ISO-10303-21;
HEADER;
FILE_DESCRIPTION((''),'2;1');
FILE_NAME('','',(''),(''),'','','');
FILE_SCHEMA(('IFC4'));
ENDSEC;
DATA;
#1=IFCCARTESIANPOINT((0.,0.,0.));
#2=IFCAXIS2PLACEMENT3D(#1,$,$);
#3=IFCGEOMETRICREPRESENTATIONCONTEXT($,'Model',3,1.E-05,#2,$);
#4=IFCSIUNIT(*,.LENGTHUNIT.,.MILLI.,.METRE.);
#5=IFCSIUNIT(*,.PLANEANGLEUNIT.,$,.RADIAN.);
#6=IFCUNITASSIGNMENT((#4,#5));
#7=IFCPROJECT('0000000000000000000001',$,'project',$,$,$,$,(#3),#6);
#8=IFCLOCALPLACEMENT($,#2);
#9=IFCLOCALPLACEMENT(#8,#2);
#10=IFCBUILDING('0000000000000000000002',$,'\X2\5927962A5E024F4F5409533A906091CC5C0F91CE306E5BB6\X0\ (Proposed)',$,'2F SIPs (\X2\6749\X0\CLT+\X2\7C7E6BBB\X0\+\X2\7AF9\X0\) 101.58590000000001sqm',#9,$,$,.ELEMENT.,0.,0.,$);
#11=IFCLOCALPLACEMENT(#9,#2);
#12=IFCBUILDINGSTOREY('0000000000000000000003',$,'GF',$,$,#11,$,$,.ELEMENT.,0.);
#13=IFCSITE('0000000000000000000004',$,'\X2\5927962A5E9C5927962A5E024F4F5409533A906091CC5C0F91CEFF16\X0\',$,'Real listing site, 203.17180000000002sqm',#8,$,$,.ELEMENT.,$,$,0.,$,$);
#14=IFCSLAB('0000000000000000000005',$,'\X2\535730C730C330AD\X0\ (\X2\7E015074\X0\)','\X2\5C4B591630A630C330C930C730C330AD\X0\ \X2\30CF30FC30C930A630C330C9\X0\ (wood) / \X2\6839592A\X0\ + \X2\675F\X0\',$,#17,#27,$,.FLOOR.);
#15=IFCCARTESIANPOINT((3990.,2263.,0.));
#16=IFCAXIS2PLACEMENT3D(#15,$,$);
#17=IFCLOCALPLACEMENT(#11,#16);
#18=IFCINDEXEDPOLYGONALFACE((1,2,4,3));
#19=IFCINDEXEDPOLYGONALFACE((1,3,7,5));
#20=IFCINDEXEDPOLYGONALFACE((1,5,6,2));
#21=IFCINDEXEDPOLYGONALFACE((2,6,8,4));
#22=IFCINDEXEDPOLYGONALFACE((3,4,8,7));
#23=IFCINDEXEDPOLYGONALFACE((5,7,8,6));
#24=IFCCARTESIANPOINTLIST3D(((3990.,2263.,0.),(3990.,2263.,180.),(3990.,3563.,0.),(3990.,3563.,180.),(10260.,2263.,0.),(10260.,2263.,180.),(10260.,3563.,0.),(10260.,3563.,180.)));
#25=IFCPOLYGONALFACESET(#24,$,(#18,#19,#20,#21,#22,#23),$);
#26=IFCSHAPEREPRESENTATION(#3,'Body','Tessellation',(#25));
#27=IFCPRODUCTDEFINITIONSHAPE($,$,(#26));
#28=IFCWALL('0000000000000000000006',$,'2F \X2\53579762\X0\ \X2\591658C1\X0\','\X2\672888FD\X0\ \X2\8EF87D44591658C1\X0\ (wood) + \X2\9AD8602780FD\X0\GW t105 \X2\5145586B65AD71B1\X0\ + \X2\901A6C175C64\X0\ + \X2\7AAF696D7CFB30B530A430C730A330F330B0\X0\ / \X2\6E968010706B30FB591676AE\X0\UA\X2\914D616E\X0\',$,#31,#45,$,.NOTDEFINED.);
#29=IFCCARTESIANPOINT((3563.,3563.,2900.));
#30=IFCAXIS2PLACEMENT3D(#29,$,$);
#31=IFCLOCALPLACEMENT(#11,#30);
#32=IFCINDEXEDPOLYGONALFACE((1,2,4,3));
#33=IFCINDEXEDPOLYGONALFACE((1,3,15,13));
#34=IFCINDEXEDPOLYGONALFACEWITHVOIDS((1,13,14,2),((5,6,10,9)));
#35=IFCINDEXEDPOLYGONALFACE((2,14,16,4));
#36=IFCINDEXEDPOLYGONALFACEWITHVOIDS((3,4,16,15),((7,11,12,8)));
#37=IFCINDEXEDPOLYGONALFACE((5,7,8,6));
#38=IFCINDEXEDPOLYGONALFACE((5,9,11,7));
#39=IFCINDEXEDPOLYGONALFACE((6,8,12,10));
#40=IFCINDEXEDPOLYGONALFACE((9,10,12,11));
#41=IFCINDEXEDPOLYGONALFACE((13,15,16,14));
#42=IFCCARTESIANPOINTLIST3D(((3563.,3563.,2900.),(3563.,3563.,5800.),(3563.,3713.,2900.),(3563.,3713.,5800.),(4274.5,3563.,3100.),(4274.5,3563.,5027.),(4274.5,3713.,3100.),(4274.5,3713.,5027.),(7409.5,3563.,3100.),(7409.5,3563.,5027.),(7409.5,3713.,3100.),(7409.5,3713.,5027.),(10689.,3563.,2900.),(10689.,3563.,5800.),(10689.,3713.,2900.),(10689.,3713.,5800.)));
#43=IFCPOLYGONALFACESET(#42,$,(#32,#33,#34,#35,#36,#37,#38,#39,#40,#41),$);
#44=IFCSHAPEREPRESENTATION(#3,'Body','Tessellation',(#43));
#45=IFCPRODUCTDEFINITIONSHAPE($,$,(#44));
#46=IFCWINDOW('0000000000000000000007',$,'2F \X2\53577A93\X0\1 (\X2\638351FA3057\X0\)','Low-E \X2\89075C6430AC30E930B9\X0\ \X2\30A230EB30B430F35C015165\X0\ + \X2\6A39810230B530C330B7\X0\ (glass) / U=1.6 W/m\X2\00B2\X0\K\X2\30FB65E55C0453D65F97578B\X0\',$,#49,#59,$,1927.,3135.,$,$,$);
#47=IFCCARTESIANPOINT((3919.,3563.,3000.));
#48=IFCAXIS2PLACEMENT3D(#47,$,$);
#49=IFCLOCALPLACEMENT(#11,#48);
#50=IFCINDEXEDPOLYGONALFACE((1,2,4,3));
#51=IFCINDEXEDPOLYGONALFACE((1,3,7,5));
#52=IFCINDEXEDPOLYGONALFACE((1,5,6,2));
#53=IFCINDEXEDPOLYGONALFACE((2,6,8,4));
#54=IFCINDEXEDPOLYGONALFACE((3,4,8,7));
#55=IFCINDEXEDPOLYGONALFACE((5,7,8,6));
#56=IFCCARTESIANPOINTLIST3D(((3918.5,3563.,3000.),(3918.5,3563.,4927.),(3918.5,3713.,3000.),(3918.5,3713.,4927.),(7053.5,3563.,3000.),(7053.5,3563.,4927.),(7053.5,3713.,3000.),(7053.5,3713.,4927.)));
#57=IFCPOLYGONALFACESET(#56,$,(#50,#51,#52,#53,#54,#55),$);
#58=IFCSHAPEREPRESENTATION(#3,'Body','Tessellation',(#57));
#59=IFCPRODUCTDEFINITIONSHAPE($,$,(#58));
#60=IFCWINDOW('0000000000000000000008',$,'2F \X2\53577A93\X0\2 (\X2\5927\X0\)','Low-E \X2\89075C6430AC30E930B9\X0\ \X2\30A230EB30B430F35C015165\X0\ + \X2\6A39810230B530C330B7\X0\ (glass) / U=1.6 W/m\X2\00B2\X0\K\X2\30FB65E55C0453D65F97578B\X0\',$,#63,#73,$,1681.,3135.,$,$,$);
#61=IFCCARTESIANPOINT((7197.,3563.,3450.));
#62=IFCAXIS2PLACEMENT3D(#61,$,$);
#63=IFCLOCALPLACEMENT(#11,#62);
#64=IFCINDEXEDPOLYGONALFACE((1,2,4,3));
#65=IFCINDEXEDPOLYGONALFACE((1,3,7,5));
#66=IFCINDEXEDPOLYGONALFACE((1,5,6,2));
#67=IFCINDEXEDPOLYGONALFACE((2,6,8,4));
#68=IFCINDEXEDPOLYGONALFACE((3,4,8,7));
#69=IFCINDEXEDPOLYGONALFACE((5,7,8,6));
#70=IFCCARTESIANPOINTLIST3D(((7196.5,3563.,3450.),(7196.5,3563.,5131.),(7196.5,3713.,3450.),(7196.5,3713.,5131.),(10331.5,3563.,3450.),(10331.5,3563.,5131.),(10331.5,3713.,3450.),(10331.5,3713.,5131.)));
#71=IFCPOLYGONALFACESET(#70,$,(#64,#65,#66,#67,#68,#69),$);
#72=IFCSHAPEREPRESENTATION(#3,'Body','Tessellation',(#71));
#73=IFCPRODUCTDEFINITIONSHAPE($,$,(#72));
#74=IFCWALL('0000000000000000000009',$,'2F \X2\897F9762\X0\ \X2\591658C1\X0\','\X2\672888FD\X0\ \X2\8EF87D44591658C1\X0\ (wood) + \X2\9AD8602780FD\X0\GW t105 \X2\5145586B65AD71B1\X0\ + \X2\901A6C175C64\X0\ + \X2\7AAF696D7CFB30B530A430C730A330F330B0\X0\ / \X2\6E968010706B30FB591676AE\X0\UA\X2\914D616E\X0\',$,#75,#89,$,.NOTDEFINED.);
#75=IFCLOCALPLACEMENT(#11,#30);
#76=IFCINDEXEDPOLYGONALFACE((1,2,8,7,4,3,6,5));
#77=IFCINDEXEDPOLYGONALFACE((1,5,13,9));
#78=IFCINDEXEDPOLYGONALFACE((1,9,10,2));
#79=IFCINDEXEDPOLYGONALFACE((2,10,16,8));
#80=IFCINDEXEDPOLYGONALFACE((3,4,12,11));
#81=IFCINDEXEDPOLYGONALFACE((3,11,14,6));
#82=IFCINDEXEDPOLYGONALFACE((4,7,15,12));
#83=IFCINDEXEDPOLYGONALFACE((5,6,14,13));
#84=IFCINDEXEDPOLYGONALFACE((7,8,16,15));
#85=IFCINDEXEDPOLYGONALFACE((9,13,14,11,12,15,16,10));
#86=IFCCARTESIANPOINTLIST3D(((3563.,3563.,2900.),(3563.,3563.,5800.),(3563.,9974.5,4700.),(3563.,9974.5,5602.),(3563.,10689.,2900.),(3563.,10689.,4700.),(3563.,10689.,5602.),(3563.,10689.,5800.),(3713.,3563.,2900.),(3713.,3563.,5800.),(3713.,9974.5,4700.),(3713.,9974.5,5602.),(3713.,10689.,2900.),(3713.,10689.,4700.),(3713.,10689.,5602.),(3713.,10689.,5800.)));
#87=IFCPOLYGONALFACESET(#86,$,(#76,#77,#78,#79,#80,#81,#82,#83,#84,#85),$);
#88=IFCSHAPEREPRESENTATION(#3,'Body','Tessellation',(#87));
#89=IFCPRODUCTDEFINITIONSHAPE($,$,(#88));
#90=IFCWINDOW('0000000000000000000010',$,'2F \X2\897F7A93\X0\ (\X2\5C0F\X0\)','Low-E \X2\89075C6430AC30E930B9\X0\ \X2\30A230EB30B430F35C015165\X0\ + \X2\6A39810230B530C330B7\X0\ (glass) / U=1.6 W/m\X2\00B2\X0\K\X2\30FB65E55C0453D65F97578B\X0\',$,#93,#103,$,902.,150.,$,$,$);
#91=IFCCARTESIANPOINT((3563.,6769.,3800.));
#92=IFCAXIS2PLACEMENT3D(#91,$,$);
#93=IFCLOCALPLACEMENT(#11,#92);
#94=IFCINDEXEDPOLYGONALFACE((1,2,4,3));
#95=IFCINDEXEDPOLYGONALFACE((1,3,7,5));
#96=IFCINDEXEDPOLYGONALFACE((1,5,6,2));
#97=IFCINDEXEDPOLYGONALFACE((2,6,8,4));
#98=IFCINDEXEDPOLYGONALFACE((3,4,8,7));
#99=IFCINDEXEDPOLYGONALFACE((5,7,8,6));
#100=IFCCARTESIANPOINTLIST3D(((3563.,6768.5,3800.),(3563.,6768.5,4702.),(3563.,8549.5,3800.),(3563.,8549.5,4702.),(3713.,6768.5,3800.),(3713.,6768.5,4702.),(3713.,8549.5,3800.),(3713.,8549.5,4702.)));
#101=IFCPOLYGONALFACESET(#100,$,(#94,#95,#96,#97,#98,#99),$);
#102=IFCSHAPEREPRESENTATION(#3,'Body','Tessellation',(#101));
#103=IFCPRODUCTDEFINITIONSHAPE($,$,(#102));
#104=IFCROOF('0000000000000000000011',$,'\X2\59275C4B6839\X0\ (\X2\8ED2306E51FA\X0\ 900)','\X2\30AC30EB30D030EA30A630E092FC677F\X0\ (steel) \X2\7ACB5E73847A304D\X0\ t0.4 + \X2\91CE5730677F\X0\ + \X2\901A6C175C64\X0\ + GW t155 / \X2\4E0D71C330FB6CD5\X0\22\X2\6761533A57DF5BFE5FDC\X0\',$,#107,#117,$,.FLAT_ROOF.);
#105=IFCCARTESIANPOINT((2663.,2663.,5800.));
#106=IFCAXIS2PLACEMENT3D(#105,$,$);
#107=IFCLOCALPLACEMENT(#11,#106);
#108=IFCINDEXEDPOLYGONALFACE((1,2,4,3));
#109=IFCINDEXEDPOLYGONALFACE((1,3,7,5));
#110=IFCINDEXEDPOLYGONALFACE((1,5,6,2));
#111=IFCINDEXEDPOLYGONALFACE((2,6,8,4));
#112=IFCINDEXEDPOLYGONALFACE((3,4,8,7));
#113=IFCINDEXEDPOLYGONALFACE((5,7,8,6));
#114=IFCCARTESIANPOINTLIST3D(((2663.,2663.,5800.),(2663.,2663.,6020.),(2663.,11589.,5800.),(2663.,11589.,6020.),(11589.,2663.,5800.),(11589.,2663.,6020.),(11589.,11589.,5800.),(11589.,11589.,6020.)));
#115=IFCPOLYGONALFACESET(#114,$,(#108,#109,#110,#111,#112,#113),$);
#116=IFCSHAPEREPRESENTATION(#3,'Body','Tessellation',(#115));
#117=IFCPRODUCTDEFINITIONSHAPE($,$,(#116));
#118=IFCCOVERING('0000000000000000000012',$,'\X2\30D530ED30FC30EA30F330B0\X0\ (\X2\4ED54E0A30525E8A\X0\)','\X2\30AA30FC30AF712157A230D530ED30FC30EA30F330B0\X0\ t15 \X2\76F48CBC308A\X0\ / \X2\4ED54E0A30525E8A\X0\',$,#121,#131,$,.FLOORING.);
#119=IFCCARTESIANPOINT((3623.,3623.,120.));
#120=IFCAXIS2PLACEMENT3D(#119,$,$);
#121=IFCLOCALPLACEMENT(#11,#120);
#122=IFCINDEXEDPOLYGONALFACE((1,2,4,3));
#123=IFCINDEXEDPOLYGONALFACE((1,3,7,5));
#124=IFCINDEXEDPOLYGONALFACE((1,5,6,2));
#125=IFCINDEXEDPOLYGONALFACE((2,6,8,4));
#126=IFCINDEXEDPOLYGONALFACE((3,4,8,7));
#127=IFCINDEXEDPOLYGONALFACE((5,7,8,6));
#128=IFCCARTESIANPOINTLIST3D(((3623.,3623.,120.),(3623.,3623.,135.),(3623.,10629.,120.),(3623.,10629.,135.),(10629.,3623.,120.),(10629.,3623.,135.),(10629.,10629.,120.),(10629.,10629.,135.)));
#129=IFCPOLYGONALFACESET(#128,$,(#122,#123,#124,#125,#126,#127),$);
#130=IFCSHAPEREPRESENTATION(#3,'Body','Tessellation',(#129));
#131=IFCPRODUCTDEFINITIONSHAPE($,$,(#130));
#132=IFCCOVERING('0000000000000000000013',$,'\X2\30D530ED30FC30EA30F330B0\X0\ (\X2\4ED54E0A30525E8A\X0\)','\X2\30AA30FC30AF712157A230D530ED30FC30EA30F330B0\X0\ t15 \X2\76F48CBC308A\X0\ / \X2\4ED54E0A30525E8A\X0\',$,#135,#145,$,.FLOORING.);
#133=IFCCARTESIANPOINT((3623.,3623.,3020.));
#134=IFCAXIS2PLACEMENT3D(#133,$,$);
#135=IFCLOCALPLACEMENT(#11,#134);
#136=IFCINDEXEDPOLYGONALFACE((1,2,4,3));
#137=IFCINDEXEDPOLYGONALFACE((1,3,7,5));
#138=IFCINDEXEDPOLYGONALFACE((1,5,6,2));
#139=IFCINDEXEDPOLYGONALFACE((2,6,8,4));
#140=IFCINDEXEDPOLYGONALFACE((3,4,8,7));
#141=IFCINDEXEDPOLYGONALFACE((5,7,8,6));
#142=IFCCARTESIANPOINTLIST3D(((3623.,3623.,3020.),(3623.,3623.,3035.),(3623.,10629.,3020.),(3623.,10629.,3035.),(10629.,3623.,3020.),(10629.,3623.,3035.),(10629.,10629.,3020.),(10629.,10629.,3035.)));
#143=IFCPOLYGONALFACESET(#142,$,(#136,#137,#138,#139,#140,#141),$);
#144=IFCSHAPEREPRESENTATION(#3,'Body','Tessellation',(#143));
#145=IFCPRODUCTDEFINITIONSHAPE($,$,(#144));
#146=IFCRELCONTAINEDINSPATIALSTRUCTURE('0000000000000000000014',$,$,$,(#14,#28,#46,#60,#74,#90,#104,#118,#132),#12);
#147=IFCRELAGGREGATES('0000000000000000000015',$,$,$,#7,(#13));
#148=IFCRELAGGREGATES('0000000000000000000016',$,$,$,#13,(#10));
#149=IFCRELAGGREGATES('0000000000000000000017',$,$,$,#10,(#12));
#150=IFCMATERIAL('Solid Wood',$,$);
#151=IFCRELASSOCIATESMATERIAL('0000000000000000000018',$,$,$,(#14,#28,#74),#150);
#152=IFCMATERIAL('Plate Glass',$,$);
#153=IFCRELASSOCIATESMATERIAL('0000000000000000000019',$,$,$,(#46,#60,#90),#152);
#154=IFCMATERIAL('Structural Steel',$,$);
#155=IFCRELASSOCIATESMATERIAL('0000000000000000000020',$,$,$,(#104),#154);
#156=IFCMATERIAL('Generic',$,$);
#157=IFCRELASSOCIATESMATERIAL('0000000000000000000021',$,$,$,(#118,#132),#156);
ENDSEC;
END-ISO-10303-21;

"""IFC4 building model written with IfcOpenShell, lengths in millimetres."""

from ifc_helpers import new_model, si_unit, frame, frame_2d, origin, place, context, project, spatial, rectangle, extrude, material, element, fill, save


model = new_model("IFC4")

# Units and contexts
model_context = context("Model", 3, precision=1e-05, world=origin())
ifc_project = project(units=[si_unit("LENGTHUNIT", "METRE", prefix="MILLI"), si_unit("PLANEANGLEUNIT", "RADIAN")], contexts=[model_context])

# Site, building, storey
site_placement = place(None, origin())
site = spatial("IfcSite", under=ifc_project, at=site_placement, Name="大阪府大阪市住吉区遠里小野６", ObjectType="Real listing site, 203.17180000000002sqm", CompositionType="ELEMENT", RefElevation=0.0)
building_placement = place(site_placement, origin())
building = spatial("IfcBuilding", under=site, at=building_placement, Name="大阪市住吉区遠里小野の家 (Proposed)", ObjectType="2F SIPs (杉CLT+籾殻+竹) 101.58590000000001sqm", CompositionType="ELEMENT", ElevationOfRefHeight=0.0, ElevationOfTerrain=0.0)
storey_placement = place(building_placement, origin())
storey = spatial("IfcBuildingStorey", under=building, at=storey_placement, Name="GF", CompositionType="ELEMENT", Elevation=0.0)

# Slab
ifc_material_1 = material(Name="Solid Wood")
slab_1_placement = place(storey_placement, frame((3990.0, 2263.0, 0.0)))
element("IfcSlab", 1, at=slab_1_placement, inside=storey, material=ifc_material_1, Name="南デッキ (縁側)", Description="屋外ウッドデッキ ハードウッド (wood) / 根太 + 束", PredefinedType="FLOOR", context=model_context, shape_type="SweptSolid", body=[
    extrude(rectangle(XDim=6270.0, YDim=1300.0, at=frame_2d((3135.0, 650.0))), frame((3990.0, 2263.0, 0.0)), (0.0, 0.0, 1.0), 180.0),
])

# Shared definitions
ifc_material_2 = material(Name="Plate Glass")

# Wall, openings, windows
wall_1_placement = place(storey_placement, frame((3563.0, 3563.0, 2900.0)))
wall_1 = element("IfcWall", 2, at=wall_1_placement, inside=storey, material=ifc_material_1, Name="2F 南面 外壁", Description="木製 軸組外壁 (wood) + 高性能GW t105 充填断熱 + 通気層 + 窯業系サイディング / 準耐火・外皮UA配慮", PredefinedType="NOTDEFINED", context=model_context, shape_type="SweptSolid", body=[
    extrude(rectangle(XDim=7126.0, YDim=150.0, at=frame_2d((3563.0, 75.0))), frame((3563.0, 3563.0, 2900.0)), (0.0, 0.0, 1.0), 2900.0),
])
opening_1_placement = place(storey_placement, frame((3919.0, 3563.0, 3000.0)))
opening_1 = element("IfcOpeningElement", 3, at=opening_1_placement, cuts=wall_1, PredefinedType="NOTDEFINED", context=model_context, shape_type="SweptSolid", body=[
    extrude(rectangle(XDim=3135.0, YDim=150.0, at=frame_2d((1567.0, 75.0))), frame((3919.0, 3563.0, 3000.0)), (0.0, 0.0, 1.0), 1927.0),
])
opening_2_placement = place(storey_placement, frame((7197.0, 3563.0, 3450.0)))
opening_2 = element("IfcOpeningElement", 4, at=opening_2_placement, cuts=wall_1, PredefinedType="NOTDEFINED", context=model_context, shape_type="SweptSolid", body=[
    extrude(rectangle(XDim=3135.0, YDim=150.0, at=frame_2d((1567.0, 75.0))), frame((7197.0, 3563.0, 3450.0)), (0.0, 0.0, 1.0), 1681.0),
])
window_1_placement = place(storey_placement, frame((3919.0, 3563.0, 3000.0)))
window_1 = element("IfcWindow", 5, at=window_1_placement, inside=storey, material=ifc_material_2, Name="2F 南窓1 (掃出し)", Description="Low-E 複層ガラス アルゴン封入 + 樹脂サッシ (glass) / U=1.6 W/m²K・日射取得型", OverallHeight=1927.0, OverallWidth=3135.0, context=model_context, shape_type="SweptSolid", body=[
    extrude(rectangle(XDim=3135.0, YDim=150.0, at=frame_2d((1567.0, 75.0))), frame((3919.0, 3563.0, 3000.0)), (0.0, 0.0, 1.0), 1927.0),
])
fill(opening_1, window_1)
window_2_placement = place(storey_placement, frame((7197.0, 3563.0, 3450.0)))
window_2 = element("IfcWindow", 6, at=window_2_placement, inside=storey, material=ifc_material_2, Name="2F 南窓2 (大)", Description="Low-E 複層ガラス アルゴン封入 + 樹脂サッシ (glass) / U=1.6 W/m²K・日射取得型", OverallHeight=1681.0, OverallWidth=3135.0, context=model_context, shape_type="SweptSolid", body=[
    extrude(rectangle(XDim=3135.0, YDim=150.0, at=frame_2d((1567.0, 75.0))), frame((7197.0, 3563.0, 3450.0)), (0.0, 0.0, 1.0), 1681.0),
])
fill(opening_2, window_2)

# Wall, opening, window
wall_2_placement = place(storey_placement, frame((3563.0, 3563.0, 2900.0)))
wall_2 = element("IfcWall", 7, at=wall_2_placement, inside=storey, material=ifc_material_1, Name="2F 西面 外壁", Description="木製 軸組外壁 (wood) + 高性能GW t105 充填断熱 + 通気層 + 窯業系サイディング / 準耐火・外皮UA配慮", PredefinedType="NOTDEFINED", context=model_context, shape_type="SweptSolid", body=[
    extrude(rectangle(XDim=150.0, YDim=7126.0, at=frame_2d((75.0, 3563.0))), frame((3563.0, 3563.0, 2900.0)), (0.0, 0.0, 1.0), 2900.0),
])
opening_3_placement = place(storey_placement, frame((3563.0, 6769.0, 3800.0)))
opening_3 = element("IfcOpeningElement", 8, at=opening_3_placement, cuts=wall_2, PredefinedType="NOTDEFINED", context=model_context, shape_type="SweptSolid", body=[
    extrude(rectangle(XDim=150.0, YDim=1781.0, at=frame_2d((75.0, 890.0))), frame((3563.0, 6769.0, 3800.0)), (0.0, 0.0, 1.0), 902.0),
])
window_3_placement = place(storey_placement, frame((3563.0, 6769.0, 3800.0)))
window_3 = element("IfcWindow", 9, at=window_3_placement, inside=storey, material=ifc_material_2, Name="2F 西窓 (小)", Description="Low-E 複層ガラス アルゴン封入 + 樹脂サッシ (glass) / U=1.6 W/m²K・日射取得型", OverallHeight=902.0, OverallWidth=150.0, context=model_context, shape_type="SweptSolid", body=[
    extrude(rectangle(XDim=150.0, YDim=1781.0, at=frame_2d((75.0, 890.0))), frame((3563.0, 6769.0, 3800.0)), (0.0, 0.0, 1.0), 902.0),
])
fill(opening_3, window_3)

# Roof
ifc_material_3 = material(Name="Structural Steel")
roof_placement = place(storey_placement, frame((2663.0, 2663.0, 5800.0)))
element("IfcRoof", 10, at=roof_placement, inside=storey, material=ifc_material_3, Name="大屋根 (軒の出 900)", Description="ガルバリウム鋼板 (steel) 立平葺き t0.4 + 野地板 + 通気層 + GW t155 / 不燃・法22条区域対応", PredefinedType="FLAT_ROOF", context=model_context, shape_type="SweptSolid", body=[
    extrude(rectangle(XDim=8926.0, YDim=8926.0, at=frame_2d((4463.0, 4463.0))), frame((2663.0, 2663.0, 5800.0)), (0.0, 0.0, 1.0), 220.0),
])

# Coverings
ifc_material_4 = material(Name="Generic")
covering_1_placement = place(storey_placement, frame((3623.0, 3623.0, 120.0)))
element("IfcCovering", 11, at=covering_1_placement, inside=storey, material=ifc_material_4, Name="フローリング (仕上げ床)", Description="オーク無垢フローリング t15 直貼り / 仕上げ床", PredefinedType="FLOORING", context=model_context, shape_type="SweptSolid", body=[
    extrude(rectangle(XDim=7006.0, YDim=7006.0, at=frame_2d((3503.0, 3503.0))), frame((3623.0, 3623.0, 120.0)), (0.0, 0.0, 1.0), 15.0),
])
covering_2_placement = place(storey_placement, frame((3623.0, 3623.0, 3020.0)))
element("IfcCovering", 12, at=covering_2_placement, inside=storey, material=ifc_material_4, Name="フローリング (仕上げ床)", Description="オーク無垢フローリング t15 直貼り / 仕上げ床", PredefinedType="FLOORING", context=model_context, shape_type="SweptSolid", body=[
    extrude(rectangle(XDim=7006.0, YDim=7006.0, at=frame_2d((3503.0, 3503.0))), frame((3623.0, 3623.0, 3020.0)), (0.0, 0.0, 1.0), 15.0),
])

save(model, "model.ifc")
